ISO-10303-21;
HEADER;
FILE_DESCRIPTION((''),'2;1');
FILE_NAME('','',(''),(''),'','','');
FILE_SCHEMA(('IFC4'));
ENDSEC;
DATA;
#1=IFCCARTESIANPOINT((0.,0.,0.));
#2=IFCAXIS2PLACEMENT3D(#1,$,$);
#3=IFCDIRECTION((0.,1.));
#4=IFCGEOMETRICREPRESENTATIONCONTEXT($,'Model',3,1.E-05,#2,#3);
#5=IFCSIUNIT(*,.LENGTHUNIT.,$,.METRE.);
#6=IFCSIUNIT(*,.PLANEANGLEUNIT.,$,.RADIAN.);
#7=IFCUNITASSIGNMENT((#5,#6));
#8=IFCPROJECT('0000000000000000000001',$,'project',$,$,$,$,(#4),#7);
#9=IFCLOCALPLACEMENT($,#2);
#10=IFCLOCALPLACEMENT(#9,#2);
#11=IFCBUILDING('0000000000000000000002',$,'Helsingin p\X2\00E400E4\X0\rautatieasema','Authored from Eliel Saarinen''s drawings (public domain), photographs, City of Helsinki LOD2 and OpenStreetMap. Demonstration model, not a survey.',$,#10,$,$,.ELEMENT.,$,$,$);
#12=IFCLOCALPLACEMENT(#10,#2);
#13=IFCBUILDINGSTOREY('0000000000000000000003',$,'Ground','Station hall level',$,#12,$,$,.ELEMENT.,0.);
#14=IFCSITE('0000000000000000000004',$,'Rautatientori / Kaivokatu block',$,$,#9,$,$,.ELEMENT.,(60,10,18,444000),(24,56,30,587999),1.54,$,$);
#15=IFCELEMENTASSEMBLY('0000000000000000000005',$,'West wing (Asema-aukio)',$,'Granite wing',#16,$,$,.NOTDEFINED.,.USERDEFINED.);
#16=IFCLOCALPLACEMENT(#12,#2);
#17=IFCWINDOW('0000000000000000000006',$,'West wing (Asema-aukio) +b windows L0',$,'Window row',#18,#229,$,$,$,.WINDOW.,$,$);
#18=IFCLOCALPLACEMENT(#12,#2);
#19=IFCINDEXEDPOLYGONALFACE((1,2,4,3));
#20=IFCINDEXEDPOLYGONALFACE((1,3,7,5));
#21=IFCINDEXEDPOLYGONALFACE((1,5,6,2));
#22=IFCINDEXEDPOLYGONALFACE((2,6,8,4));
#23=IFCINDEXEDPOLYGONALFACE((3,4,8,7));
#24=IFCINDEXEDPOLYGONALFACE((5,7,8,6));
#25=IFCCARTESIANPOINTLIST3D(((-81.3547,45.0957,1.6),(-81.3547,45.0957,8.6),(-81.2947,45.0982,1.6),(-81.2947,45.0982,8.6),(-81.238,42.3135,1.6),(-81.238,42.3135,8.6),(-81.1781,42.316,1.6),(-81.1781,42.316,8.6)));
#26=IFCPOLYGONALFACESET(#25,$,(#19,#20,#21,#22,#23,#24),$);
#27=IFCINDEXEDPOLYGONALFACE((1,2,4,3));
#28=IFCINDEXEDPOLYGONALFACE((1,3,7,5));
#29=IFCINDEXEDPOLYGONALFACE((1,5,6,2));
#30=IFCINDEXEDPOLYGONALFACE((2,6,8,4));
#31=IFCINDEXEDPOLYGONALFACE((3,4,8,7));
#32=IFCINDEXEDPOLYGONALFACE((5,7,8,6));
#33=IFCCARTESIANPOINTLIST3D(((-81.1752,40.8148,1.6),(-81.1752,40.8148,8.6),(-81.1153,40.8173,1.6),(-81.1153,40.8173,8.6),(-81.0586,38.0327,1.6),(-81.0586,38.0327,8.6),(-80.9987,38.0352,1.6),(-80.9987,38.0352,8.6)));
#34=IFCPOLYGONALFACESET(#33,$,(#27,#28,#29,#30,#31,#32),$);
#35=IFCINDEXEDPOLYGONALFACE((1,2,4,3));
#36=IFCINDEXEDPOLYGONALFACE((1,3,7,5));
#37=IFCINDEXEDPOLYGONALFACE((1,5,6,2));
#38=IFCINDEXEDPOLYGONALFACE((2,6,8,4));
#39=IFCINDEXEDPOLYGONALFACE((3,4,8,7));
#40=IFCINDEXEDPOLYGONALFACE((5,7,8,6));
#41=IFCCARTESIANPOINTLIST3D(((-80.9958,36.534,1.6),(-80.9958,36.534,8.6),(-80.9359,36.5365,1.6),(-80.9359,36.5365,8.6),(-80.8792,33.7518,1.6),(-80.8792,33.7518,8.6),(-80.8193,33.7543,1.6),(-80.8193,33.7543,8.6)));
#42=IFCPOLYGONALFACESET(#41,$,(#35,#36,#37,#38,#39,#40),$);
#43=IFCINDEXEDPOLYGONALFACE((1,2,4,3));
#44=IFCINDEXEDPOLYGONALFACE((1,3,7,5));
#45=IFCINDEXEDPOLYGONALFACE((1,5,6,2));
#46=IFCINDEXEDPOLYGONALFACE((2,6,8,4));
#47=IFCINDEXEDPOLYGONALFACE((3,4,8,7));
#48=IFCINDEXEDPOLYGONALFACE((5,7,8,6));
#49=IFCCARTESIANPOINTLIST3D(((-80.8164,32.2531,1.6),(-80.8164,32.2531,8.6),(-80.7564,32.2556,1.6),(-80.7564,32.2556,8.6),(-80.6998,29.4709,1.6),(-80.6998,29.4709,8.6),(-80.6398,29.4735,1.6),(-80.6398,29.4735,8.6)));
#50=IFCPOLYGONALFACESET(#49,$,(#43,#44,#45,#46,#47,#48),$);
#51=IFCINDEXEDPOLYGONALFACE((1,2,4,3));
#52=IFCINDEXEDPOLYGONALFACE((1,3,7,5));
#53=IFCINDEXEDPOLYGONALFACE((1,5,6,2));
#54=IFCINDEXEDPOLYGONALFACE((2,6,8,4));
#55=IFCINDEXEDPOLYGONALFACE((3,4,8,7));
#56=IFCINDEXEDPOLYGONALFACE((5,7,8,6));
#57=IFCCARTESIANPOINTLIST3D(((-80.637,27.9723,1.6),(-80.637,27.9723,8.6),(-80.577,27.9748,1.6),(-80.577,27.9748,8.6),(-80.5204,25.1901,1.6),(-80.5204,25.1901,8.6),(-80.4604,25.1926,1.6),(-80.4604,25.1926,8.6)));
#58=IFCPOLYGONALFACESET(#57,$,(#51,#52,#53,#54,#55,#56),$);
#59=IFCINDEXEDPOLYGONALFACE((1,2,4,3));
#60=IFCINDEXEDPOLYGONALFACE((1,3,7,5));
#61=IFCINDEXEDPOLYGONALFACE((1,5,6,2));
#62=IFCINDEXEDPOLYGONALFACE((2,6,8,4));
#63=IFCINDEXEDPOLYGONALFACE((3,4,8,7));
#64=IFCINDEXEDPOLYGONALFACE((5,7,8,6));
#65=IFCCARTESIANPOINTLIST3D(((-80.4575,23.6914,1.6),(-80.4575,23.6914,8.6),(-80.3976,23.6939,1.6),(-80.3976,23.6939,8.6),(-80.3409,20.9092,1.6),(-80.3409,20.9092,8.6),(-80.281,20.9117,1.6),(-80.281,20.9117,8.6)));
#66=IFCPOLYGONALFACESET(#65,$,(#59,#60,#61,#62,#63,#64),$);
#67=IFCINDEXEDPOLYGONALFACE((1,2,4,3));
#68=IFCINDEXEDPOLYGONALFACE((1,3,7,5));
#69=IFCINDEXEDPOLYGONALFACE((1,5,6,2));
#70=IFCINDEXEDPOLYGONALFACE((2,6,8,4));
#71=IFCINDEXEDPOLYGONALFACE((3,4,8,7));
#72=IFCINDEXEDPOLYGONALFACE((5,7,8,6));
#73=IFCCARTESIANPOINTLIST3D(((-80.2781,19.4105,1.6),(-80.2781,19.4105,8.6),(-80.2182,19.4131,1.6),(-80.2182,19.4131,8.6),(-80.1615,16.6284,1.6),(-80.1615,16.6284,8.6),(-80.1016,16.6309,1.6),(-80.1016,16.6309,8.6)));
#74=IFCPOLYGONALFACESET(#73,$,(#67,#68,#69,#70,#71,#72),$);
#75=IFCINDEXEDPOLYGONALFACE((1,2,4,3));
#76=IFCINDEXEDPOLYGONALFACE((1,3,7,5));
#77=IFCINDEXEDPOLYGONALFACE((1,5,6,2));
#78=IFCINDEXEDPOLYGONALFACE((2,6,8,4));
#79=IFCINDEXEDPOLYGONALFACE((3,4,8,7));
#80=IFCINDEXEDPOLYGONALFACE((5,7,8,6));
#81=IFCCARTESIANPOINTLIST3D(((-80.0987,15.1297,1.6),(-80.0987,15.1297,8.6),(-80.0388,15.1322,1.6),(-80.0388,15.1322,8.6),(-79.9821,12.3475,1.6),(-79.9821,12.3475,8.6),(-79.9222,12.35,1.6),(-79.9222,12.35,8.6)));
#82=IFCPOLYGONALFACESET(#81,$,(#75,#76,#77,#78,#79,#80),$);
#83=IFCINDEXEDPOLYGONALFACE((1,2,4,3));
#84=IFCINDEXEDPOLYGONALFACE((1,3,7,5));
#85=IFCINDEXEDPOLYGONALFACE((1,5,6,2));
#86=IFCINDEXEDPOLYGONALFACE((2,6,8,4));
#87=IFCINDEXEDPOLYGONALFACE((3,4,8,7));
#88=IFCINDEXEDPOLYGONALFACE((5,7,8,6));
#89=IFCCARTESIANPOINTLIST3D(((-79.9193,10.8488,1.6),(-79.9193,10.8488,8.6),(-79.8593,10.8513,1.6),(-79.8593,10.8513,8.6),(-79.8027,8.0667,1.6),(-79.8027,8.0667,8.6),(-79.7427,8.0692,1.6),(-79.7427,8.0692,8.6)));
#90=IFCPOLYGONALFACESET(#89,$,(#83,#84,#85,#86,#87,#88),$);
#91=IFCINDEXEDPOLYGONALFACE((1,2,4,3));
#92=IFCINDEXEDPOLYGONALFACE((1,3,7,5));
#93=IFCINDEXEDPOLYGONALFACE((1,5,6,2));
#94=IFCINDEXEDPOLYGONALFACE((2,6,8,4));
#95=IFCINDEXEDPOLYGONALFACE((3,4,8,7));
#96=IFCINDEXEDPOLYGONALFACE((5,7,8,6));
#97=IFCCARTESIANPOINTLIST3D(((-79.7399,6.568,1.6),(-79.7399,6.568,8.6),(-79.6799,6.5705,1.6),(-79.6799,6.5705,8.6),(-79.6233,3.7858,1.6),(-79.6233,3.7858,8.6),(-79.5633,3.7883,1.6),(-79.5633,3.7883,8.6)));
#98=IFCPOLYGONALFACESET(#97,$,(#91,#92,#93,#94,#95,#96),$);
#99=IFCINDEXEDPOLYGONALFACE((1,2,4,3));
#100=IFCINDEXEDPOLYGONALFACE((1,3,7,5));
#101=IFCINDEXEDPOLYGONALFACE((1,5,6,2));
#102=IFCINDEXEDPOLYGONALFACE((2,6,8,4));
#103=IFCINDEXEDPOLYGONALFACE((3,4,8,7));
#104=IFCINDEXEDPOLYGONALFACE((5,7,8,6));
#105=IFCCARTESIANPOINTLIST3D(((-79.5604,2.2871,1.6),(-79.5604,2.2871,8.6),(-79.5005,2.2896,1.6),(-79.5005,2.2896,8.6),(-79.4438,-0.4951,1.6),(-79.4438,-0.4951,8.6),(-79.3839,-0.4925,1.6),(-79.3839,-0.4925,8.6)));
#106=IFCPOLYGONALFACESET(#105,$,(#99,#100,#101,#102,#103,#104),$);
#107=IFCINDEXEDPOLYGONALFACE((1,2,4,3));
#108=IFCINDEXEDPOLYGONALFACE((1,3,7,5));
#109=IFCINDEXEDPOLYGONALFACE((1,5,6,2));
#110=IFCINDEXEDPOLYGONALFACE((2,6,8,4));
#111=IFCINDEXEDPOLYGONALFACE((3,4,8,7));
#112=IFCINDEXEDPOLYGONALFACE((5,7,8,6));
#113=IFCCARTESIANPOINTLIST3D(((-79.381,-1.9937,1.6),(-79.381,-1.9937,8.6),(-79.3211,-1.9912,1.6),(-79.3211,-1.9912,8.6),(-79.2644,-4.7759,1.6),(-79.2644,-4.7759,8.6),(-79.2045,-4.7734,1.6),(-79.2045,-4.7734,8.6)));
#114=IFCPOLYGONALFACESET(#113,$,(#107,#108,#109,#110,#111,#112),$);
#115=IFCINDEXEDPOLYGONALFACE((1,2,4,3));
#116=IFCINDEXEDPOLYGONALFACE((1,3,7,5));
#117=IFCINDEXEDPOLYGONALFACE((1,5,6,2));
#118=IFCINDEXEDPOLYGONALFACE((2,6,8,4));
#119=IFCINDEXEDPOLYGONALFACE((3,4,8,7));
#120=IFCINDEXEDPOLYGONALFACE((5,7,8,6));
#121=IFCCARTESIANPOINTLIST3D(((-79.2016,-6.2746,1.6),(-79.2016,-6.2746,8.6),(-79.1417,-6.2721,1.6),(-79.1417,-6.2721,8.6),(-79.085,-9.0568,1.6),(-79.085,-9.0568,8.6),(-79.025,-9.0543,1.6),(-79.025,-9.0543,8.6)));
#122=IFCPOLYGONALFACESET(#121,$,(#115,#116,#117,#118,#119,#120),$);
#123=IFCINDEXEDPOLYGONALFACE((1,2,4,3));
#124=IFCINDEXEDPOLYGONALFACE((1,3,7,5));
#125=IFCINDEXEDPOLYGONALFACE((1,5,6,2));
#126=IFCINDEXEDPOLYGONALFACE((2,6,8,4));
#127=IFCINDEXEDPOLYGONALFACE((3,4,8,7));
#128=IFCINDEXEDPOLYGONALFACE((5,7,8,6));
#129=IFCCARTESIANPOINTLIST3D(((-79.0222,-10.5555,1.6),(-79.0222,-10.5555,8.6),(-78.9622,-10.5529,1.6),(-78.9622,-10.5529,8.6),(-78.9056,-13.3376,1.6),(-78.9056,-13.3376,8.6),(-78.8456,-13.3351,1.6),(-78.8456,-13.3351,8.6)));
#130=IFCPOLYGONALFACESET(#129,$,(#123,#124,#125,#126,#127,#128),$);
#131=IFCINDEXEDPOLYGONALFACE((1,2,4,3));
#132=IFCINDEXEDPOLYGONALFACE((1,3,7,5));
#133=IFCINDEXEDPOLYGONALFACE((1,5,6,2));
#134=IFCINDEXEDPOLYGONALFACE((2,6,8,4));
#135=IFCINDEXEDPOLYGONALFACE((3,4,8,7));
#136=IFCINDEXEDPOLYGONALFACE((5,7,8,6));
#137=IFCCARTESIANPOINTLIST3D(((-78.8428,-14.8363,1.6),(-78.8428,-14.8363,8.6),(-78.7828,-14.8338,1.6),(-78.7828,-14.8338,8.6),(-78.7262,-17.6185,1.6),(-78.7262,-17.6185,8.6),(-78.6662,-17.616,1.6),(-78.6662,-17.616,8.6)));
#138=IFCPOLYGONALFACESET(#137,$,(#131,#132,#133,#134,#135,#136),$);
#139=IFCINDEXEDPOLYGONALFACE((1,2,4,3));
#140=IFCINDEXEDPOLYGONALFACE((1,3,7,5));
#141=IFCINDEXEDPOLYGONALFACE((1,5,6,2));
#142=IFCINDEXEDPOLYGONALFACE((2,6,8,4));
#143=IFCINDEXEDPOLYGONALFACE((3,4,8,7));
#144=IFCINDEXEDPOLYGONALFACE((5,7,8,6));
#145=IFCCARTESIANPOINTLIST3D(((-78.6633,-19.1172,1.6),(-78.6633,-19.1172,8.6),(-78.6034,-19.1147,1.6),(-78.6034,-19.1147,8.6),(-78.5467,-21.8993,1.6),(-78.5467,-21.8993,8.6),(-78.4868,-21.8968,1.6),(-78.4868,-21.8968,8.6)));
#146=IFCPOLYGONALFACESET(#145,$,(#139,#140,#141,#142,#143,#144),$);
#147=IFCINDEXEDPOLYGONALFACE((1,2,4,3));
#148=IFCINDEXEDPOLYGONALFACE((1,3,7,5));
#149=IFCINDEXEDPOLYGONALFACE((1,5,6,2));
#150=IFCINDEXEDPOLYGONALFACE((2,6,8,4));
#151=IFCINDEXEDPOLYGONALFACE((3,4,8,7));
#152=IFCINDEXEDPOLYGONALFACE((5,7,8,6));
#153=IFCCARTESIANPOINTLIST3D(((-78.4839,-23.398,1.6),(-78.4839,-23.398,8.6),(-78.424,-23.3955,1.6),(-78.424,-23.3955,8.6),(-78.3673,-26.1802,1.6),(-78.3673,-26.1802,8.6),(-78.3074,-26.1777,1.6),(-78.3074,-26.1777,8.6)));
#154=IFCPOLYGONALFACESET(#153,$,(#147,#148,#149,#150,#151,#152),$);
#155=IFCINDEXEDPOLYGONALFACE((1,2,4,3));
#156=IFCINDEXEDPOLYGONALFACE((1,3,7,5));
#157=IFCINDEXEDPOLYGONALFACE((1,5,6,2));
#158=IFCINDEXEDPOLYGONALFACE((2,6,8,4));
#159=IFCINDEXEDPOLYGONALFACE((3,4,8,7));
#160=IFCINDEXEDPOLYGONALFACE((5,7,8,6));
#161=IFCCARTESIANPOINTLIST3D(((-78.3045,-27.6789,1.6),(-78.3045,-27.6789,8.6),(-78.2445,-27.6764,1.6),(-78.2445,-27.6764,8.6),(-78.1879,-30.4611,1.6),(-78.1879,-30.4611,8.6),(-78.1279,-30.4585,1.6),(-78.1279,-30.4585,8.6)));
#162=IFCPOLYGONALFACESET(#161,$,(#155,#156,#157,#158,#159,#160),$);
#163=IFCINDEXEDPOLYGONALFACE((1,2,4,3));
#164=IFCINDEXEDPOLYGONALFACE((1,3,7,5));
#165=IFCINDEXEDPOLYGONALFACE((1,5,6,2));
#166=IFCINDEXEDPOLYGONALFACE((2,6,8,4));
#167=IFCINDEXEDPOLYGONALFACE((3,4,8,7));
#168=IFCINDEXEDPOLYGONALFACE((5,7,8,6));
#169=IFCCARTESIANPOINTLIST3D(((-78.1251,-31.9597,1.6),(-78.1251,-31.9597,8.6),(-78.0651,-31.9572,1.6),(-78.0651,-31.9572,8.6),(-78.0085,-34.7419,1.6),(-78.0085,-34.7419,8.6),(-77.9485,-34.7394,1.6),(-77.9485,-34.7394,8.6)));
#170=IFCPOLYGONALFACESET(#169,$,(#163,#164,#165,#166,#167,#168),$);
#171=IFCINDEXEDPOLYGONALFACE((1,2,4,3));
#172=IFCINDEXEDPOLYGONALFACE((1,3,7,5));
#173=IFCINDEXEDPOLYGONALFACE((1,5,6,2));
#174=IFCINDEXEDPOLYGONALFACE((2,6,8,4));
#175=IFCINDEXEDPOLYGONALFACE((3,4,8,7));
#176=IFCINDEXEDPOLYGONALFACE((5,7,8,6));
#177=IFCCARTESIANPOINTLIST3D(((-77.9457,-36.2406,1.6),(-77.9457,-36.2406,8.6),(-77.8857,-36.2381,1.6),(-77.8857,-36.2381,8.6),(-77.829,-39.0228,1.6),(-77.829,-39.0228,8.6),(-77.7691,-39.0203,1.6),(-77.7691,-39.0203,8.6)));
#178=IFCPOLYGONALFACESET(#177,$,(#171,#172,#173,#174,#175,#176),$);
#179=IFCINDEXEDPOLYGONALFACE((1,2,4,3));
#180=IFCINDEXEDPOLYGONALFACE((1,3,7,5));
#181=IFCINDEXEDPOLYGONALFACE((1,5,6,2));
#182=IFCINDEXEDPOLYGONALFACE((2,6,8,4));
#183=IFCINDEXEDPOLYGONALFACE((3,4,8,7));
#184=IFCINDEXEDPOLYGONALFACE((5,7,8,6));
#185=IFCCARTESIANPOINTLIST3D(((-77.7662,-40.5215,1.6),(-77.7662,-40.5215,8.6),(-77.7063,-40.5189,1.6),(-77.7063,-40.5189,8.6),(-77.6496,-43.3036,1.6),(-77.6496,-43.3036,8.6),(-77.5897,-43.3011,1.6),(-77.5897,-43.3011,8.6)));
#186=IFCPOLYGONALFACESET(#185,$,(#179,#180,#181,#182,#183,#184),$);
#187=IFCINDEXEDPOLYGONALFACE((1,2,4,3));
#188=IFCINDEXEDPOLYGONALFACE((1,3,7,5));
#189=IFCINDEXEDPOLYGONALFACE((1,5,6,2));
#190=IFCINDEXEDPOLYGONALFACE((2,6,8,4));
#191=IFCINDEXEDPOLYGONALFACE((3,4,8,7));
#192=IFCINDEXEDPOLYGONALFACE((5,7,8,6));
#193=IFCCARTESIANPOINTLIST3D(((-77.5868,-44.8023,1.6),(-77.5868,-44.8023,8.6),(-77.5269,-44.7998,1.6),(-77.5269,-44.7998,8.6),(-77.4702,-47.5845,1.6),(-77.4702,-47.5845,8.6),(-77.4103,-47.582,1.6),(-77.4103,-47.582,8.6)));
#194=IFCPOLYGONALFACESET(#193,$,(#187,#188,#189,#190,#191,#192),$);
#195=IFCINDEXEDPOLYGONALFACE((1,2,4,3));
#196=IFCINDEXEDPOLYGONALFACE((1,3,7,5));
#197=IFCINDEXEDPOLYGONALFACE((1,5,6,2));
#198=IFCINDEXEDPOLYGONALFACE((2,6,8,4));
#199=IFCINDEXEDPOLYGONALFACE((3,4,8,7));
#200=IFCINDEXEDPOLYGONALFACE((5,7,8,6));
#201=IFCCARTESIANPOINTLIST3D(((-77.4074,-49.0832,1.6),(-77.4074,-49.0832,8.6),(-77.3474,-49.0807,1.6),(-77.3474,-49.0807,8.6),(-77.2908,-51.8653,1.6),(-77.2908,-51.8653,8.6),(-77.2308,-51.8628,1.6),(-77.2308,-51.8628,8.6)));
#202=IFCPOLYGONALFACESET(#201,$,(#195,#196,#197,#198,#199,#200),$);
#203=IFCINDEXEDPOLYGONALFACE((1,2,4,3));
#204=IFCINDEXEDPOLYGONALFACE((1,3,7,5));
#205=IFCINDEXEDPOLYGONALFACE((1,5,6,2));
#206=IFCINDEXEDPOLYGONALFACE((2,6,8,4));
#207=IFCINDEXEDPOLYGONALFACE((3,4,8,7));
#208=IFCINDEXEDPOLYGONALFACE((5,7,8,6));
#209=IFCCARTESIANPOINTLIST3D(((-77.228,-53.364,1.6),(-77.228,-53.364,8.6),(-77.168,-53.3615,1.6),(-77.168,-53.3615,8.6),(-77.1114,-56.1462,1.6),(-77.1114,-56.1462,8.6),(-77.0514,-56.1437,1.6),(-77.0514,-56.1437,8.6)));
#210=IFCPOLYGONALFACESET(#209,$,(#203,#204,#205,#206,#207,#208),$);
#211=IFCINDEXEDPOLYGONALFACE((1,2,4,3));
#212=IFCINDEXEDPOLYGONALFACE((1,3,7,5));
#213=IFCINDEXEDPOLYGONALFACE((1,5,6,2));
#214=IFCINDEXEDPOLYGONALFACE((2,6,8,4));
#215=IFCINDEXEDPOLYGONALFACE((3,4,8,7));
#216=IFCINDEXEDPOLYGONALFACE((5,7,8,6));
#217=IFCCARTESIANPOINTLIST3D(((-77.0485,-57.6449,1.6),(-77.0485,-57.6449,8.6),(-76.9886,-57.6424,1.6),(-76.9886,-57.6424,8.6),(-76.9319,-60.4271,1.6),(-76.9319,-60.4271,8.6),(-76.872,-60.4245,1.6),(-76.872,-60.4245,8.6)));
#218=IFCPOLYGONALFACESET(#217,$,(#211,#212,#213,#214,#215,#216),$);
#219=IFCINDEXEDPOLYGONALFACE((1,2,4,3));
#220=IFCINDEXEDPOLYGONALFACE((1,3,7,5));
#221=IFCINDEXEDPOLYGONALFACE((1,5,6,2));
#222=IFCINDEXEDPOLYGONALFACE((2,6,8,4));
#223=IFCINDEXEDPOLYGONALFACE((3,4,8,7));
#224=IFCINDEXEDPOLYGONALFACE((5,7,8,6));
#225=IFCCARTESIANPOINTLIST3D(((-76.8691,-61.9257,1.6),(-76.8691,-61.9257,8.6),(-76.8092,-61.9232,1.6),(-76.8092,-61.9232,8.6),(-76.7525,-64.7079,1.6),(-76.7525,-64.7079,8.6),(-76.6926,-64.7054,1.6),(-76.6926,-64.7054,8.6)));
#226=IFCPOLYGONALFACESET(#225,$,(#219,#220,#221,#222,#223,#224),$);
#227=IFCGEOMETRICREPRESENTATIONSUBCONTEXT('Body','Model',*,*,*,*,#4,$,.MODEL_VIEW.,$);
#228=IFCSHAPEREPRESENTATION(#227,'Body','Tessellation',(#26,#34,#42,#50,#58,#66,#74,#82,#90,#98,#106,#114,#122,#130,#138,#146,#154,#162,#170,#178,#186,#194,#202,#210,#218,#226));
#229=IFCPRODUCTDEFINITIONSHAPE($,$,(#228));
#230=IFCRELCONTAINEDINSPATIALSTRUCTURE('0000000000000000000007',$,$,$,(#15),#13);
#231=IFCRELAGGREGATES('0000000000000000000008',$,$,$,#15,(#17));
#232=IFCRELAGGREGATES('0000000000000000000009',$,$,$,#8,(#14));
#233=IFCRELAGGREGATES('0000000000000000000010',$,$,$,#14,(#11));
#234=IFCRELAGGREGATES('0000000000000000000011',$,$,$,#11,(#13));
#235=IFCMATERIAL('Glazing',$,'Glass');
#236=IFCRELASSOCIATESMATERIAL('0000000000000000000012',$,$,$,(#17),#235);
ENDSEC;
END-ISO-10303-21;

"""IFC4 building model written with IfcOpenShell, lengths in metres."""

from ifc_helpers import new_model, si_unit, direction, frame, frame_2d, origin, place, context, subcontext, project, spatial, rectangle, extrude, material, element, aggregate, save


model = new_model("IFC4")

# Units and contexts
model_context = context("Model", 3, precision=1e-05, world=origin(), true_north=direction((0.0, 1.0)))
body_context = subcontext(model_context, "Body", "Model", "MODEL_VIEW")
ifc_project = project(units=[si_unit("LENGTHUNIT", "METRE"), si_unit("PLANEANGLEUNIT", "RADIAN")], contexts=[model_context])

# Site, building, storey
site_placement = place(None, origin())
site = spatial("IfcSite", under=ifc_project, at=site_placement, Name="Rautatientori / Kaivokatu block", CompositionType="ELEMENT", RefLatitude=(60, 10, 18, 444000), RefLongitude=(24, 56, 30, 587999), RefElevation=1.54)
building_placement = place(site_placement, origin())
building = spatial("IfcBuilding", under=site, at=building_placement, Name="Helsingin päärautatieasema", Description="Authored from Eliel Saarinen's drawings (public domain), photographs, City of Helsinki LOD2 and OpenStreetMap. Demonstration model, not a survey.", CompositionType="ELEMENT")
storey_placement = place(building_placement, origin())
storey = spatial("IfcBuildingStorey", under=building, at=storey_placement, Name="Ground", Description="Station hall level", CompositionType="ELEMENT", Elevation=0.0)

# Element assembly, window
assembly_placement = place(building_placement, origin())
assembly = element("IfcElementAssembly", 1, at=assembly_placement, inside=storey, Name="West wing (Asema-aukio)", ObjectType="Granite wing", AssemblyPlace="NOTDEFINED", PredefinedType="USERDEFINED")
ifc_material_1 = material(Name="Glazing", Category="Glass")
window_1_placement = place(building_placement, origin())
window_1 = element("IfcWindow", 2, at=window_1_placement, material=ifc_material_1, Name="West wing (Asema-aukio) +b windows L0", ObjectType="Window row", PredefinedType="WINDOW", context=body_context, shape_type="SweptSolid", body=[
    extrude(rectangle(XDim=2.7846, YDim=0.06, at=frame_2d((0.0, 0.0), x_axis=(0.041876, -0.999123))), frame((-81.2664, 43.7059, 1.6)), (0.0, 0.0, 1.0), 7.0),
    extrude(rectangle(XDim=2.7846, YDim=0.06, at=frame_2d((0.0, 0.0), x_axis=(0.041876, -0.999123))), frame((-81.087, 39.425, 1.6)), (0.0, 0.0, 1.0), 7.0),
    extrude(rectangle(XDim=2.7846, YDim=0.06, at=frame_2d((0.0, 0.0), x_axis=(0.041876, -0.999123))), frame((-80.9075, 35.1441, 1.6)), (0.0, 0.0, 1.0), 7.0),
    extrude(rectangle(XDim=2.7846, YDim=0.06, at=frame_2d((0.0, 0.0), x_axis=(0.041876, -0.999123))), frame((-80.7281, 30.8633, 1.6)), (0.0, 0.0, 1.0), 7.0),
    extrude(rectangle(XDim=2.7846, YDim=0.06, at=frame_2d((0.0, 0.0), x_axis=(0.041876, -0.999123))), frame((-80.5487, 26.5824, 1.6)), (0.0, 0.0, 1.0), 7.0),
    extrude(rectangle(XDim=2.7846, YDim=0.06, at=frame_2d((0.0, 0.0), x_axis=(0.041876, -0.999123))), frame((-80.3693, 22.3016, 1.6)), (0.0, 0.0, 1.0), 7.0),
    extrude(rectangle(XDim=2.7846, YDim=0.06, at=frame_2d((0.0, 0.0), x_axis=(0.041876, -0.999123))), frame((-80.1899, 18.0207, 1.6)), (0.0, 0.0, 1.0), 7.0),
    extrude(rectangle(XDim=2.7846, YDim=0.06, at=frame_2d((0.0, 0.0), x_axis=(0.041876, -0.999123))), frame((-80.0104, 13.7399, 1.6)), (0.0, 0.0, 1.0), 7.0),
    extrude(rectangle(XDim=2.7846, YDim=0.06, at=frame_2d((0.0, 0.0), x_axis=(0.041876, -0.999123))), frame((-79.831, 9.459, 1.6)), (0.0, 0.0, 1.0), 7.0),
    extrude(rectangle(XDim=2.7846, YDim=0.06, at=frame_2d((0.0, 0.0), x_axis=(0.041876, -0.999123))), frame((-79.6516, 5.1781, 1.6)), (0.0, 0.0, 1.0), 7.0),
    extrude(rectangle(XDim=2.7846, YDim=0.06, at=frame_2d((0.0, 0.0), x_axis=(0.041876, -0.999123))), frame((-79.4722, 0.8973, 1.6)), (0.0, 0.0, 1.0), 7.0),
    extrude(rectangle(XDim=2.7846, YDim=0.06, at=frame_2d((0.0, 0.0), x_axis=(0.041876, -0.999123))), frame((-79.2927, -3.3836, 1.6)), (0.0, 0.0, 1.0), 7.0),
    extrude(rectangle(XDim=2.7846, YDim=0.06, at=frame_2d((0.0, 0.0), x_axis=(0.041876, -0.999123))), frame((-79.1133, -7.6644, 1.6)), (0.0, 0.0, 1.0), 7.0),
    extrude(rectangle(XDim=2.7846, YDim=0.06, at=frame_2d((0.0, 0.0), x_axis=(0.041876, -0.999123))), frame((-78.9339, -11.9453, 1.6)), (0.0, 0.0, 1.0), 7.0),
    extrude(rectangle(XDim=2.7846, YDim=0.06, at=frame_2d((0.0, 0.0), x_axis=(0.041876, -0.999123))), frame((-78.7545, -16.2261, 1.6)), (0.0, 0.0, 1.0), 7.0),
    extrude(rectangle(XDim=2.7846, YDim=0.06, at=frame_2d((0.0, 0.0), x_axis=(0.041876, -0.999123))), frame((-78.5751, -20.507, 1.6)), (0.0, 0.0, 1.0), 7.0),
    extrude(rectangle(XDim=2.7846, YDim=0.06, at=frame_2d((0.0, 0.0), x_axis=(0.041876, -0.999123))), frame((-78.3956, -24.7879, 1.6)), (0.0, 0.0, 1.0), 7.0),
    extrude(rectangle(XDim=2.7846, YDim=0.06, at=frame_2d((0.0, 0.0), x_axis=(0.041876, -0.999123))), frame((-78.2162, -29.0687, 1.6)), (0.0, 0.0, 1.0), 7.0),
    extrude(rectangle(XDim=2.7846, YDim=0.06, at=frame_2d((0.0, 0.0), x_axis=(0.041876, -0.999123))), frame((-78.0368, -33.3496, 1.6)), (0.0, 0.0, 1.0), 7.0),
    extrude(rectangle(XDim=2.7846, YDim=0.06, at=frame_2d((0.0, 0.0), x_axis=(0.041876, -0.999123))), frame((-77.8574, -37.6304, 1.6)), (0.0, 0.0, 1.0), 7.0),
    extrude(rectangle(XDim=2.7846, YDim=0.06, at=frame_2d((0.0, 0.0), x_axis=(0.041876, -0.999123))), frame((-77.678, -41.9113, 1.6)), (0.0, 0.0, 1.0), 7.0),
    extrude(rectangle(XDim=2.7846, YDim=0.06, at=frame_2d((0.0, 0.0), x_axis=(0.041876, -0.999123))), frame((-77.4985, -46.1921, 1.6)), (0.0, 0.0, 1.0), 7.0),
    extrude(rectangle(XDim=2.7846, YDim=0.06, at=frame_2d((0.0, 0.0), x_axis=(0.041876, -0.999123))), frame((-77.3191, -50.473, 1.6)), (0.0, 0.0, 1.0), 7.0),
    extrude(rectangle(XDim=2.7846, YDim=0.06, at=frame_2d((0.0, 0.0), x_axis=(0.041876, -0.999123))), frame((-77.1397, -54.7539, 1.6)), (0.0, 0.0, 1.0), 7.0),
    extrude(rectangle(XDim=2.7846, YDim=0.06, at=frame_2d((0.0, 0.0), x_axis=(0.041876, -0.999123))), frame((-76.9603, -59.0347, 1.6)), (0.0, 0.0, 1.0), 7.0),
    extrude(rectangle(XDim=2.7846, YDim=0.06, at=frame_2d((0.0, 0.0), x_axis=(0.041876, -0.999123))), frame((-76.7809, -63.3156, 1.6)), (0.0, 0.0, 1.0), 7.0),
])
aggregate(assembly, [window_1])

save(model, "model.ifc")
